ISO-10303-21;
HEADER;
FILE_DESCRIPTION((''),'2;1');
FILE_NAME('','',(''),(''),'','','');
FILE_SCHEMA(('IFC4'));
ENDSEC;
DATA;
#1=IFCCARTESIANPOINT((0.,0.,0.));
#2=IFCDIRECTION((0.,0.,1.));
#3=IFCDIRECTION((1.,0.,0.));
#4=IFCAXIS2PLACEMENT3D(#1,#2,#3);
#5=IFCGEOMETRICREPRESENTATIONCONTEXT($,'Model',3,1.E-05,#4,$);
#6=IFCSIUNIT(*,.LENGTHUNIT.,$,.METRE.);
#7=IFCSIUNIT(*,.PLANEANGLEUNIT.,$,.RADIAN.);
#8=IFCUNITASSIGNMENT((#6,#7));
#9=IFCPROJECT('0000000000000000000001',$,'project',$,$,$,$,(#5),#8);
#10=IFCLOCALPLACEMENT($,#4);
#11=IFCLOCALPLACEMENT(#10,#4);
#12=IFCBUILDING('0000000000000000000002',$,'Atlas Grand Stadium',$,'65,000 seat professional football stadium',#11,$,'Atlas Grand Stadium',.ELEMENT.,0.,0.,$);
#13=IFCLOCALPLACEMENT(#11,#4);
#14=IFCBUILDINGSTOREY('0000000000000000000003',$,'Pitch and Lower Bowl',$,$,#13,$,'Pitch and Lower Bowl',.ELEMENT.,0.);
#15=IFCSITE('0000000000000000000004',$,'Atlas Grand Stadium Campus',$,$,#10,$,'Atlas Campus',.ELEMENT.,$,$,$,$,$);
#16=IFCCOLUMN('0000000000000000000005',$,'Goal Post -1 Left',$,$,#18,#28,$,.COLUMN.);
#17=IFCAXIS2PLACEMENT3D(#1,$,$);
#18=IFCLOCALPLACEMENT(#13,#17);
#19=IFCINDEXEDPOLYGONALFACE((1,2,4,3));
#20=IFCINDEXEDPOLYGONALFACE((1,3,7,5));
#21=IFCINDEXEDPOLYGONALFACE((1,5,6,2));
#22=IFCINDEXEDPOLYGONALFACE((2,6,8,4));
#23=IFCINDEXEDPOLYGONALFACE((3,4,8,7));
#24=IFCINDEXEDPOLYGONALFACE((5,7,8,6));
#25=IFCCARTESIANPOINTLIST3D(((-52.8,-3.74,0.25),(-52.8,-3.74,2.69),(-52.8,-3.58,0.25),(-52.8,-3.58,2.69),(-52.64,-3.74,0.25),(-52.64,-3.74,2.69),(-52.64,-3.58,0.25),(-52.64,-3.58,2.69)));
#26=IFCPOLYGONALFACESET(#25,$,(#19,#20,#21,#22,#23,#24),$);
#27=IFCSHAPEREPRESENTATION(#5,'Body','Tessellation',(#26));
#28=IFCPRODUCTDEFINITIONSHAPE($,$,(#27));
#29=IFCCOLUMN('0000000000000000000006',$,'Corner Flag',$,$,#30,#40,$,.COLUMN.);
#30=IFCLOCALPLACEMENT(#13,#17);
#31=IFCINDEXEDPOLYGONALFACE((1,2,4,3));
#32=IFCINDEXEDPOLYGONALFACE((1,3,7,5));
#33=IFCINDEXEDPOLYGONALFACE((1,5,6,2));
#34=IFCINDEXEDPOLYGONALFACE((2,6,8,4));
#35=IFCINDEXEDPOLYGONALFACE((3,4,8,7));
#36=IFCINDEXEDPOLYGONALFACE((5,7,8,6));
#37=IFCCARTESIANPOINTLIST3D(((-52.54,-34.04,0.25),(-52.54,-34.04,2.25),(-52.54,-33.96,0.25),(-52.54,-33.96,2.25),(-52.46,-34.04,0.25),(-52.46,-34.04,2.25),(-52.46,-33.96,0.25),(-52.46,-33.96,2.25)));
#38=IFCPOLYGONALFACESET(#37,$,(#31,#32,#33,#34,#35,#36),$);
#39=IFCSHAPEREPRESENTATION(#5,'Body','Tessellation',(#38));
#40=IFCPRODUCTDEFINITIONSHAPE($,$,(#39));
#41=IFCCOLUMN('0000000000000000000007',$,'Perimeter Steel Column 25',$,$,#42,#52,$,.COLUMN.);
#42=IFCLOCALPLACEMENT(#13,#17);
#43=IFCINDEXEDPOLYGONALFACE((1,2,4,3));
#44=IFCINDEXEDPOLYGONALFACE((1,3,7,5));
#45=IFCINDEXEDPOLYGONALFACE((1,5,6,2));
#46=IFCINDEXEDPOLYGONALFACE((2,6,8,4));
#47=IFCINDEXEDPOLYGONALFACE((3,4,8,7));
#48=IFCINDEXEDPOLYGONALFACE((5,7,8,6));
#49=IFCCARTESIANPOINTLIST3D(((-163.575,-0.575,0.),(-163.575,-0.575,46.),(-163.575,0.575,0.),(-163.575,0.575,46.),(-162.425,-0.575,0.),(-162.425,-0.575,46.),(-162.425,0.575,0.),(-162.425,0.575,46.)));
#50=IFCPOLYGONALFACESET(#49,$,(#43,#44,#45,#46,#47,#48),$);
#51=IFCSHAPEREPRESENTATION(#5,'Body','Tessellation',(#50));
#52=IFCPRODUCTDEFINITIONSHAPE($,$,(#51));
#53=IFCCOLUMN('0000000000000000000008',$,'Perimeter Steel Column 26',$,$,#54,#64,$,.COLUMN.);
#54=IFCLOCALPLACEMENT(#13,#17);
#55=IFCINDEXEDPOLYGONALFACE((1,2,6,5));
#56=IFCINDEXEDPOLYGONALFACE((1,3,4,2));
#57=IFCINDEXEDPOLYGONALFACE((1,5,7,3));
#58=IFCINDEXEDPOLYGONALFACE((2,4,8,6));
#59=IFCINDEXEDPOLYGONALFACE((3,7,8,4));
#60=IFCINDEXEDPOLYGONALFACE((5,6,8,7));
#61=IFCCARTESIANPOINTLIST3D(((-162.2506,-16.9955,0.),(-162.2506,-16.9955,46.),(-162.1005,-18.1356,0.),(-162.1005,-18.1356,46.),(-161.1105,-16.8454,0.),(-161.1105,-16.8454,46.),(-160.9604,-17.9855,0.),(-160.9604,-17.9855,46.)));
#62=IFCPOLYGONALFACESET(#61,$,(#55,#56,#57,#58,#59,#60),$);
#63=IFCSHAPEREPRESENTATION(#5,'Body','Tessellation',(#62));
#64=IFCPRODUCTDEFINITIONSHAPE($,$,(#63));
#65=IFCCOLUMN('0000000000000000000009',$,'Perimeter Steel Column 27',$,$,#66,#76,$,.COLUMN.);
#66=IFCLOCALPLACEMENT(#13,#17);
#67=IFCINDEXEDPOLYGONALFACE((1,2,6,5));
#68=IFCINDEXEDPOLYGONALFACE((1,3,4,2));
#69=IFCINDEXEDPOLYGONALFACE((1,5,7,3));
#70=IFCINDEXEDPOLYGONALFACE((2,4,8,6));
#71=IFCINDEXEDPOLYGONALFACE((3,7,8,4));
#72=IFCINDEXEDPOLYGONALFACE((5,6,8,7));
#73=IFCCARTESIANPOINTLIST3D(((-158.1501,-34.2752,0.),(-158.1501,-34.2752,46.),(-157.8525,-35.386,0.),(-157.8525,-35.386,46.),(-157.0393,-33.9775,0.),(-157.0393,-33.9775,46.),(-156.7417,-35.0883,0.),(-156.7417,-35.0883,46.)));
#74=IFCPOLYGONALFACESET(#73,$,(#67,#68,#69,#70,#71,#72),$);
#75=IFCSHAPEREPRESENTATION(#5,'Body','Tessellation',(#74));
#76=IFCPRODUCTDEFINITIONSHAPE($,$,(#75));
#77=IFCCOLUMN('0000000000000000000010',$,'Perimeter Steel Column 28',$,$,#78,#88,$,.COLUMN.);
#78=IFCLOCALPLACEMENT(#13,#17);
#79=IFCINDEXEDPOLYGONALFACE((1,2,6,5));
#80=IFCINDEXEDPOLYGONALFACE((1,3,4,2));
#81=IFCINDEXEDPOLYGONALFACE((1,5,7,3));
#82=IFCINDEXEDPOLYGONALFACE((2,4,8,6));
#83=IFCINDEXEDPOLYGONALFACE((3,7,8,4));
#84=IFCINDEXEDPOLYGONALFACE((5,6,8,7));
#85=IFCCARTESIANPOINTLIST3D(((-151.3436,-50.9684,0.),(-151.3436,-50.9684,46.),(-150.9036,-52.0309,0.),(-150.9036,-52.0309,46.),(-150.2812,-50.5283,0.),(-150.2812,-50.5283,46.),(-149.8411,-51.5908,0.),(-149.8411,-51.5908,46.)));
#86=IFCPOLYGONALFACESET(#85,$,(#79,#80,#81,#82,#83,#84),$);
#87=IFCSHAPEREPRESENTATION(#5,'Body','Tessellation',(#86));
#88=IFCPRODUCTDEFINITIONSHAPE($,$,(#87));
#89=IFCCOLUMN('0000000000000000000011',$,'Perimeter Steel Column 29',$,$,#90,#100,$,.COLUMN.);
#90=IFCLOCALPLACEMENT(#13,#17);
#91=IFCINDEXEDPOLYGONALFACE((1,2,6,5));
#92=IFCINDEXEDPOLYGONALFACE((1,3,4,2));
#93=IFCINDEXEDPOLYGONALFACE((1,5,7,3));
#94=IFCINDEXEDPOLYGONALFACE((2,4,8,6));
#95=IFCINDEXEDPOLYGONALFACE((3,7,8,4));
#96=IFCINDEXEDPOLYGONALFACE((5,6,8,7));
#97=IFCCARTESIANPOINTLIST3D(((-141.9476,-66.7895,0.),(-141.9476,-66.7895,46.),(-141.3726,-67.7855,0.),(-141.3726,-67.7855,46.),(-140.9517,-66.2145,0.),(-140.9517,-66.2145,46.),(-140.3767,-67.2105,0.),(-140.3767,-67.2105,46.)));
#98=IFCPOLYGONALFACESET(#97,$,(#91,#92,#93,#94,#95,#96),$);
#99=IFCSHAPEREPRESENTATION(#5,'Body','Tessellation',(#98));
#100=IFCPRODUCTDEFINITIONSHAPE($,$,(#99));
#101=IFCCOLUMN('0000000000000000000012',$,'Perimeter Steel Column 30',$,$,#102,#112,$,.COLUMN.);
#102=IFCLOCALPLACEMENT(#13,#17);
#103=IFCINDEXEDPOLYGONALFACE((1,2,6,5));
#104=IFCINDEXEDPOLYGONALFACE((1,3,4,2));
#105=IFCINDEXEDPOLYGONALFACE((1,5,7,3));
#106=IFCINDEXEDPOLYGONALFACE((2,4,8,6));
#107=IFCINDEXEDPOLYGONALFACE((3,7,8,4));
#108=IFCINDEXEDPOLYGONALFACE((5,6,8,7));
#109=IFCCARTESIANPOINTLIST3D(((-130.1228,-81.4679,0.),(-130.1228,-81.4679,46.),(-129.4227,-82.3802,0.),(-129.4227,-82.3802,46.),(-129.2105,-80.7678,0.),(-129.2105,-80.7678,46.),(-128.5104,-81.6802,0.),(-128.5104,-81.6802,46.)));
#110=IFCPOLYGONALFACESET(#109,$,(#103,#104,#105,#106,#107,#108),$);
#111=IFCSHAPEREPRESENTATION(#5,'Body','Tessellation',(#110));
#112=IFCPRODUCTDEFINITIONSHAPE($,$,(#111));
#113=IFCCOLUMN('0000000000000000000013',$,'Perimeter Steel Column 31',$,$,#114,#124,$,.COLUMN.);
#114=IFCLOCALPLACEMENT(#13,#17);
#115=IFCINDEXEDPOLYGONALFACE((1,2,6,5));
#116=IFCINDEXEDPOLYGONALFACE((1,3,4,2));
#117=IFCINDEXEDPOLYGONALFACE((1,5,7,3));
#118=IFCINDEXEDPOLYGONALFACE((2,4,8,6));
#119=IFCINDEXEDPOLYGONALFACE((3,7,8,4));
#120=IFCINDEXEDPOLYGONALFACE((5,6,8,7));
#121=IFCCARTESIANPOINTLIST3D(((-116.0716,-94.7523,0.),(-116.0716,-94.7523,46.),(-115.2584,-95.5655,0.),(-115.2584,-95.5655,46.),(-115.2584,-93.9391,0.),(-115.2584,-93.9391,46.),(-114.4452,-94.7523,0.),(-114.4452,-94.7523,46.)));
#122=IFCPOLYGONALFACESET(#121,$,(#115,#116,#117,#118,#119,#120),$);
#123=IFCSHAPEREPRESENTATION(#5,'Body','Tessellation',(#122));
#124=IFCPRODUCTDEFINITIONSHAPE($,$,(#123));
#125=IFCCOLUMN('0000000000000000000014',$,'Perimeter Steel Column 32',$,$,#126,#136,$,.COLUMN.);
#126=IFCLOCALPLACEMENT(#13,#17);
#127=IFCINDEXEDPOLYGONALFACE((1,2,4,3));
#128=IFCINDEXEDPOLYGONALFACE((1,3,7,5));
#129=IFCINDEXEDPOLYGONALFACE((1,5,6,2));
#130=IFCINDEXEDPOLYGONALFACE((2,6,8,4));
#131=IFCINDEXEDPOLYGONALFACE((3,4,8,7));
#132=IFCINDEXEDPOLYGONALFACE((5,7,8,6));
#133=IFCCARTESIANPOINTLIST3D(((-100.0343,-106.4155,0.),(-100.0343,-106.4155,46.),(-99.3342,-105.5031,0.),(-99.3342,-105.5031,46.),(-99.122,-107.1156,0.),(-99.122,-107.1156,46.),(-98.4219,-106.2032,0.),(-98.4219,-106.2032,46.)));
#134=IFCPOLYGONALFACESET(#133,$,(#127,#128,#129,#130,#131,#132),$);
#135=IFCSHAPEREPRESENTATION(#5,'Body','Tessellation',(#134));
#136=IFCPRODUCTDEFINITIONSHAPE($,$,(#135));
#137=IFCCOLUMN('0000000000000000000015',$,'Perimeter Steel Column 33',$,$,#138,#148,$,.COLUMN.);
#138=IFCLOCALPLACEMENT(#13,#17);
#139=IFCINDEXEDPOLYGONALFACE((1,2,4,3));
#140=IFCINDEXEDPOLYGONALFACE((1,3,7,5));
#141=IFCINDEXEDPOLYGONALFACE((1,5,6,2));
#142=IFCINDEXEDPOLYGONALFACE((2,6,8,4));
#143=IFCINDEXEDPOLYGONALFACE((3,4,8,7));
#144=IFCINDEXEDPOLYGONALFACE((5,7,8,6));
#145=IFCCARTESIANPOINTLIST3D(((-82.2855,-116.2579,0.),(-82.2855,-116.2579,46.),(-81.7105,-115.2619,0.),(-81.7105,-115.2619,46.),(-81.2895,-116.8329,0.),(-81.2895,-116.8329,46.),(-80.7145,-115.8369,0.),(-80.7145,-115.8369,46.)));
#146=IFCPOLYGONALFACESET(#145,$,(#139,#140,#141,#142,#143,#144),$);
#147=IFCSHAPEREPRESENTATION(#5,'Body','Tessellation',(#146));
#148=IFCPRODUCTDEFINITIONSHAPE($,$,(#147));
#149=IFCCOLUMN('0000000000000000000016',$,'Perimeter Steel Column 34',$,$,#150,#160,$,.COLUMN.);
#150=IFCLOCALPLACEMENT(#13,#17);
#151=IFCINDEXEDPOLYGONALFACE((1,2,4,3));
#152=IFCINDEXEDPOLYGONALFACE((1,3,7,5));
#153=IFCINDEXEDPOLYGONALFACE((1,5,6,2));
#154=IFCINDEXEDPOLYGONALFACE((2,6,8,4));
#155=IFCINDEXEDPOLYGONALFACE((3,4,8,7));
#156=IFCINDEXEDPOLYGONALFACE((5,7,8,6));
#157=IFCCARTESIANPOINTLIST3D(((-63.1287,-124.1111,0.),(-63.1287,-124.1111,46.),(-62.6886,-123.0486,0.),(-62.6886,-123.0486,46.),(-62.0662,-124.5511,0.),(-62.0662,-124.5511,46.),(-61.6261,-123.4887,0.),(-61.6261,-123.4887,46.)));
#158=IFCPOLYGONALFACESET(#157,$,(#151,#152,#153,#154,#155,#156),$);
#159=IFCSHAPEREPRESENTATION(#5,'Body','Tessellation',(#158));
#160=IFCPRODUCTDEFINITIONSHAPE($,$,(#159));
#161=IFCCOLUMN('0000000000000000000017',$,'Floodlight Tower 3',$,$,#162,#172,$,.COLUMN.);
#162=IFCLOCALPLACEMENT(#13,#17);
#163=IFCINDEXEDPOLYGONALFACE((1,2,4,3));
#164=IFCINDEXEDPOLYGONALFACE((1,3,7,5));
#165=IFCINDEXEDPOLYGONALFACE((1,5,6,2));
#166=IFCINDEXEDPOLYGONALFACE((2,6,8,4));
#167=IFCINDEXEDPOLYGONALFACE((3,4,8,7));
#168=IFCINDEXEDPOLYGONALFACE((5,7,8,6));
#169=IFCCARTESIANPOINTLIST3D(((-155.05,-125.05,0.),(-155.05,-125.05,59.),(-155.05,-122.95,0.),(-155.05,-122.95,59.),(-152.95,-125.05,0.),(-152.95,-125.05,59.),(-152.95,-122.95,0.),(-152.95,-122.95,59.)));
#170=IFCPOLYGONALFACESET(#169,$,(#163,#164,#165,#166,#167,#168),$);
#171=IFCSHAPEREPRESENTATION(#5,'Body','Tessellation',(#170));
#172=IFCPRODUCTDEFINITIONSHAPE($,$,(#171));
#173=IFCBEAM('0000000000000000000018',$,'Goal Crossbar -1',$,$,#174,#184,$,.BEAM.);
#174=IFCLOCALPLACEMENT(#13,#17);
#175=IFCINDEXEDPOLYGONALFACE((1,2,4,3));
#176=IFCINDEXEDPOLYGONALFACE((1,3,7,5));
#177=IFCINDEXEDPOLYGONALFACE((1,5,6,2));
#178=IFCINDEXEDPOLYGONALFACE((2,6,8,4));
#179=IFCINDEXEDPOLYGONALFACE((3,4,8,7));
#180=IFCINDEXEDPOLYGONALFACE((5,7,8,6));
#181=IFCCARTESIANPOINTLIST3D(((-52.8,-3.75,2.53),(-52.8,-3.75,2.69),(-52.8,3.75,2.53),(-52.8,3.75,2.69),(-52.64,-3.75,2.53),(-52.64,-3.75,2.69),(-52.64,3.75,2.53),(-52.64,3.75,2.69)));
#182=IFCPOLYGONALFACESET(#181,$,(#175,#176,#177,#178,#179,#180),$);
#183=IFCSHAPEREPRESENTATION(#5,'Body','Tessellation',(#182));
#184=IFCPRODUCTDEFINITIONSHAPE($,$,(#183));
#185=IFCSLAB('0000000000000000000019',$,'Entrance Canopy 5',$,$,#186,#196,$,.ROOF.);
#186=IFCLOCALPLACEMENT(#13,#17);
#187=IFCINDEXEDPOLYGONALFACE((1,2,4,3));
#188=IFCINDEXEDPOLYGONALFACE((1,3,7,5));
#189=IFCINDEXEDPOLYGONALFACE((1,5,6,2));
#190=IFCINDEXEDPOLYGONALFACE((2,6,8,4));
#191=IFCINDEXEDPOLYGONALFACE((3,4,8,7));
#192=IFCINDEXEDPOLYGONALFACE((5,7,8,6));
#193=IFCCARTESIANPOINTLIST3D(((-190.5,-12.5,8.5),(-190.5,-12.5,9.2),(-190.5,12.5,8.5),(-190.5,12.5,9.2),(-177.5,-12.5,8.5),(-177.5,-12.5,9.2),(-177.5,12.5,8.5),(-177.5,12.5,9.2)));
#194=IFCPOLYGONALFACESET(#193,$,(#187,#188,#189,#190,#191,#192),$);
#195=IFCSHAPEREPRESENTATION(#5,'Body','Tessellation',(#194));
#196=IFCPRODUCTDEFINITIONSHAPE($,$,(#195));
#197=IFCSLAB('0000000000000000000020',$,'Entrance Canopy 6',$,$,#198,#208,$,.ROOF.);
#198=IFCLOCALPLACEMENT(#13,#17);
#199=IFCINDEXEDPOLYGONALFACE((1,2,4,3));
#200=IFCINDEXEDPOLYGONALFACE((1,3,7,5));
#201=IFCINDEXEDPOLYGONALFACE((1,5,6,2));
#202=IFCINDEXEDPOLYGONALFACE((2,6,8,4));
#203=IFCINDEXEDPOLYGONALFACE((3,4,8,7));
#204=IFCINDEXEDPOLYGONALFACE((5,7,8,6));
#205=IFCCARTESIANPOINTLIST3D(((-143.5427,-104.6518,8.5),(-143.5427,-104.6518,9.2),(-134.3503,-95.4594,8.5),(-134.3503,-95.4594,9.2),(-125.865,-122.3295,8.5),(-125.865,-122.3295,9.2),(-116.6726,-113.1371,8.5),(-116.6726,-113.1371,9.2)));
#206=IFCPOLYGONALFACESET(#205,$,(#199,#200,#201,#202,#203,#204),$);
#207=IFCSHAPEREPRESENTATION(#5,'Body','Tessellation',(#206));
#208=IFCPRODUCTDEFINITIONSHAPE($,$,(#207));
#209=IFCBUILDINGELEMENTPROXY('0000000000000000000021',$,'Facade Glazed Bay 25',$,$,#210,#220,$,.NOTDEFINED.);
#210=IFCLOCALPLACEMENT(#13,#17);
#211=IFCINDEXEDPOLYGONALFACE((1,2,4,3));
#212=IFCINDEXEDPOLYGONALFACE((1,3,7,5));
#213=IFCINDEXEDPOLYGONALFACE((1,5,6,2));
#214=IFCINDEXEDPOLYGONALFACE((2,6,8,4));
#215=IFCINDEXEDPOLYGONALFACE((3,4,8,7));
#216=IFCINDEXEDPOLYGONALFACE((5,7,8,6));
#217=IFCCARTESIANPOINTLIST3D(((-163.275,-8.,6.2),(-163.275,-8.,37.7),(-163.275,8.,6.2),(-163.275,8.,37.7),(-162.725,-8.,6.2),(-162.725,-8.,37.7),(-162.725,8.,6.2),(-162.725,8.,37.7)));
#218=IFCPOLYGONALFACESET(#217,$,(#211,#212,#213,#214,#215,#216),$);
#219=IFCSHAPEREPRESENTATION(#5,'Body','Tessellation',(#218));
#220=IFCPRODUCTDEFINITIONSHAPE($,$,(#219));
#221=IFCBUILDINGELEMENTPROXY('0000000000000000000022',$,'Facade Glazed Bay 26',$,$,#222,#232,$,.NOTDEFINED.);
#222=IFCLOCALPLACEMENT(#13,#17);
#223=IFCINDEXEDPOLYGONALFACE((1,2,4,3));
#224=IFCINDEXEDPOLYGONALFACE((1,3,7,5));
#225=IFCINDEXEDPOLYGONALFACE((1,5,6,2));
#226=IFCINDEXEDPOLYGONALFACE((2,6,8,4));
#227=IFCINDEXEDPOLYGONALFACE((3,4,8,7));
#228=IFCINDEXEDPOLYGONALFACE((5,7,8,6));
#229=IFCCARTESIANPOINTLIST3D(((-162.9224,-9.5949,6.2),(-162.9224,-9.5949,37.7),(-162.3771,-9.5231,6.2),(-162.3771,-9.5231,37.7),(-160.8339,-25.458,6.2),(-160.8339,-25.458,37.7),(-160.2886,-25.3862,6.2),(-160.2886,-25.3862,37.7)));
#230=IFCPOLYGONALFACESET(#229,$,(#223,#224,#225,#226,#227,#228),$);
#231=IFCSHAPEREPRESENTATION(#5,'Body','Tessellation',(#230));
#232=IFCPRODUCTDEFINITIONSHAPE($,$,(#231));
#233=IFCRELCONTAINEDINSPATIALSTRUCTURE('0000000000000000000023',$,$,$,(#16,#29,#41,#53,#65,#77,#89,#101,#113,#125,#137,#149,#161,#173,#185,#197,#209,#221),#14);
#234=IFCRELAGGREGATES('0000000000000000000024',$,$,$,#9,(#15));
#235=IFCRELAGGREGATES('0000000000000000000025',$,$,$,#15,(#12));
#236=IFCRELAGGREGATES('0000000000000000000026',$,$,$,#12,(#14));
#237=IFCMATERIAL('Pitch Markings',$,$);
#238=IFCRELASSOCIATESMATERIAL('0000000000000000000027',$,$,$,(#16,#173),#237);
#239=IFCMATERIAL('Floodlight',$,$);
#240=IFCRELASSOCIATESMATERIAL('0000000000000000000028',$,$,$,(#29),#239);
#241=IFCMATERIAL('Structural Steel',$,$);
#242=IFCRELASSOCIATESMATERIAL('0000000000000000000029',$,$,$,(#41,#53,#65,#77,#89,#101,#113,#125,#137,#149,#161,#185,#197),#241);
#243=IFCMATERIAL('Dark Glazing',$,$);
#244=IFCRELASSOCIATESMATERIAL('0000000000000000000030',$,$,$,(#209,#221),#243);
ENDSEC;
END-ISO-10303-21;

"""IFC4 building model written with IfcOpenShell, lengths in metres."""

from ifc_helpers import new_model, si_unit, frame, origin_with_axes, origin_2d_with_axis, place, context, project, spatial, rectangle, extrude, material, element, save


model = new_model("IFC4")

# Units and contexts
model_context = context("Model", 3, precision=1e-05, world=origin_with_axes())
ifc_project = project(units=[si_unit("LENGTHUNIT", "METRE"), si_unit("PLANEANGLEUNIT", "RADIAN")], contexts=[model_context])

# Site, building, storey
site_placement = place(None, origin_with_axes())
site = spatial("IfcSite", under=ifc_project, at=site_placement, Name="Atlas Grand Stadium Campus", LongName="Atlas Campus", CompositionType="ELEMENT")
building_placement = place(site_placement, origin_with_axes())
building = spatial("IfcBuilding", under=site, at=building_placement, Name="Atlas Grand Stadium", ObjectType="65,000 seat professional football stadium", LongName="Atlas Grand Stadium", CompositionType="ELEMENT", ElevationOfRefHeight=0.0, ElevationOfTerrain=0.0)
storey_placement = place(building_placement, origin_with_axes())
storey = spatial("IfcBuildingStorey", under=building, at=storey_placement, Name="Pitch and Lower Bowl", LongName="Pitch and Lower Bowl", CompositionType="ELEMENT", Elevation=0.0)

# Columns
ifc_material_1 = material(Name="Pitch Markings")
column_1_placement = place(storey_placement, frame((-52.72, -3.66, 0.25), z_axis=(0.0, 0.0, 1.0), x_axis=(1.0, 0.0, 0.0)))
element("IfcColumn", 1, at=column_1_placement, inside=storey, material=ifc_material_1, Name="Goal Post -1 Left", PredefinedType="COLUMN", context=model_context, shape_type="SweptSolid", body=[
    extrude(rectangle(XDim=0.16, YDim=0.16, at=origin_2d_with_axis()), origin_with_axes(), (0.0, 0.0, 1.0), 2.44),
])
ifc_material_2 = material(Name="Floodlight")
column_2_placement = place(storey_placement, frame((-52.5, -34.0, 0.25), z_axis=(0.0, 0.0, 1.0), x_axis=(1.0, 0.0, 0.0)))
element("IfcColumn", 2, at=column_2_placement, inside=storey, material=ifc_material_2, Name="Corner Flag", PredefinedType="COLUMN", context=model_context, shape_type="SweptSolid", body=[
    extrude(rectangle(XDim=0.08, YDim=0.08, at=origin_2d_with_axis()), origin_with_axes(), (0.0, 0.0, 1.0), 2.0),
])
ifc_material_3 = material(Name="Structural Steel")
for number, where, z_axis, x_axis, name in (
    (3, (-163.0, 0.0, 0.0), (0.0, 0.0, 1.0), (0.0, -1.0, 0.0), "Perimeter Steel Column 25"),
    (4, (-161.6055, -17.4905, 0.0), (0.0, 0.0, 1.0), (0.13053, -0.99144, 0.0), "Perimeter Steel Column 26"),
    (5, (-157.4459, -34.6818, 0.0), (0.0, 0.0, 1.0), (0.25882, -0.96593, 0.0), "Perimeter Steel Column 27"),
    (6, (-150.5924, -51.2796, 0.0), (0.0, 0.0, 1.0), (0.38268, -0.92388, 0.0), "Perimeter Steel Column 28"),
    (7, (-141.1621, -67.0, 0.0), (0.0, 0.0, 1.0), (0.5, -0.86603, 0.0), "Perimeter Steel Column 29"),
    (8, (-129.3166, -81.574, 0.0), (0.0, 0.0, 1.0), (0.60876, -0.79335, 0.0), "Perimeter Steel Column 30"),
    (9, (-115.2584, -94.7523, 0.0), (0.0, 0.0, 1.0), (0.70711, -0.70711, 0.0), "Perimeter Steel Column 31"),
    (10, (-99.2281, -106.3093, 0.0), (0.0, 0.0, 1.0), (0.79335, -0.60876, 0.0), "Perimeter Steel Column 32"),
    (11, (-81.5, -116.0474, 0.0), (0.0, 0.0, 1.0), (0.86603, -0.5, 0.0), "Perimeter Steel Column 33"),
    (12, (-62.3774, -123.7999, 0.0), (0.0, 0.0, 1.0), (0.92388, -0.38268, 0.0), "Perimeter Steel Column 34"),
):
    element("IfcColumn", number, at=place(storey_placement, frame(where, z_axis=z_axis, x_axis=x_axis)), inside=storey, material=ifc_material_3, Name=name, PredefinedType="COLUMN", context=model_context, shape_type="SweptSolid", body=[
        extrude(rectangle(XDim=1.15, YDim=1.15, at=origin_2d_with_axis()), origin_with_axes(), (0.0, 0.0, 1.0), 46.0),
    ])
column_3_placement = place(storey_placement, frame((-154.0, -124.0, 0.0), z_axis=(0.0, 0.0, 1.0), x_axis=(1.0, 0.0, 0.0)))
element("IfcColumn", 13, at=column_3_placement, inside=storey, material=ifc_material_3, Name="Floodlight Tower 3", PredefinedType="COLUMN", context=model_context, shape_type="SweptSolid", body=[
    extrude(rectangle(XDim=2.1, YDim=2.1, at=origin_2d_with_axis()), origin_with_axes(), (0.0, 0.0, 1.0), 59.0),
])

# Beam
beam_placement = place(storey_placement, frame((-52.72, 0.0, 2.53), z_axis=(0.0, 0.0, 1.0), x_axis=(1.0, 0.0, 0.0)))
element("IfcBeam", 14, at=beam_placement, inside=storey, material=ifc_material_1, Name="Goal Crossbar -1", PredefinedType="BEAM", context=model_context, shape_type="SweptSolid", body=[
    extrude(rectangle(XDim=0.16, YDim=7.5, at=origin_2d_with_axis()), origin_with_axes(), (0.0, 0.0, 1.0), 0.16),
])

# Slabs
for number, where, z_axis, x_axis, name in (
    (15, (-184.0, 0.0, 8.5), (0.0, 0.0, 1.0), (0.0, -1.0, 0.0), "Entrance Canopy 5"),
    (16, (-130.1077, -108.8944, 8.5), (0.0, 0.0, 1.0), (0.70711, -0.70711, 0.0), "Entrance Canopy 6"),
):
    element("IfcSlab", number, at=place(storey_placement, frame(where, z_axis=z_axis, x_axis=x_axis)), inside=storey, material=ifc_material_3, Name=name, PredefinedType="ROOF", context=model_context, shape_type="SweptSolid", body=[
        extrude(rectangle(XDim=25.0, YDim=13.0, at=origin_2d_with_axis()), origin_with_axes(), (0.0, 0.0, 1.0), 0.7),
    ])

# Building element proxies
ifc_material_4 = material(Name="Dark Glazing")
for number, where, z_axis, x_axis, name in (
    (17, (-163.0, 0.0, 6.2), (0.0, 0.0, 1.0), (0.0, -1.0, 0.0), "Facade Glazed Bay 25"),
    (18, (-161.6055, -17.4905, 6.2), (0.0, 0.0, 1.0), (0.13053, -0.99144, 0.0), "Facade Glazed Bay 26"),
):
    element("IfcBuildingElementProxy", number, at=place(storey_placement, frame(where, z_axis=z_axis, x_axis=x_axis)), inside=storey, material=ifc_material_4, Name=name, PredefinedType="NOTDEFINED", context=model_context, shape_type="SweptSolid", body=[
        extrude(rectangle(XDim=16.0, YDim=0.55, at=origin_2d_with_axis()), origin_with_axes(), (0.0, 0.0, 1.0), 31.5),
    ])

save(model, "model.ifc")
